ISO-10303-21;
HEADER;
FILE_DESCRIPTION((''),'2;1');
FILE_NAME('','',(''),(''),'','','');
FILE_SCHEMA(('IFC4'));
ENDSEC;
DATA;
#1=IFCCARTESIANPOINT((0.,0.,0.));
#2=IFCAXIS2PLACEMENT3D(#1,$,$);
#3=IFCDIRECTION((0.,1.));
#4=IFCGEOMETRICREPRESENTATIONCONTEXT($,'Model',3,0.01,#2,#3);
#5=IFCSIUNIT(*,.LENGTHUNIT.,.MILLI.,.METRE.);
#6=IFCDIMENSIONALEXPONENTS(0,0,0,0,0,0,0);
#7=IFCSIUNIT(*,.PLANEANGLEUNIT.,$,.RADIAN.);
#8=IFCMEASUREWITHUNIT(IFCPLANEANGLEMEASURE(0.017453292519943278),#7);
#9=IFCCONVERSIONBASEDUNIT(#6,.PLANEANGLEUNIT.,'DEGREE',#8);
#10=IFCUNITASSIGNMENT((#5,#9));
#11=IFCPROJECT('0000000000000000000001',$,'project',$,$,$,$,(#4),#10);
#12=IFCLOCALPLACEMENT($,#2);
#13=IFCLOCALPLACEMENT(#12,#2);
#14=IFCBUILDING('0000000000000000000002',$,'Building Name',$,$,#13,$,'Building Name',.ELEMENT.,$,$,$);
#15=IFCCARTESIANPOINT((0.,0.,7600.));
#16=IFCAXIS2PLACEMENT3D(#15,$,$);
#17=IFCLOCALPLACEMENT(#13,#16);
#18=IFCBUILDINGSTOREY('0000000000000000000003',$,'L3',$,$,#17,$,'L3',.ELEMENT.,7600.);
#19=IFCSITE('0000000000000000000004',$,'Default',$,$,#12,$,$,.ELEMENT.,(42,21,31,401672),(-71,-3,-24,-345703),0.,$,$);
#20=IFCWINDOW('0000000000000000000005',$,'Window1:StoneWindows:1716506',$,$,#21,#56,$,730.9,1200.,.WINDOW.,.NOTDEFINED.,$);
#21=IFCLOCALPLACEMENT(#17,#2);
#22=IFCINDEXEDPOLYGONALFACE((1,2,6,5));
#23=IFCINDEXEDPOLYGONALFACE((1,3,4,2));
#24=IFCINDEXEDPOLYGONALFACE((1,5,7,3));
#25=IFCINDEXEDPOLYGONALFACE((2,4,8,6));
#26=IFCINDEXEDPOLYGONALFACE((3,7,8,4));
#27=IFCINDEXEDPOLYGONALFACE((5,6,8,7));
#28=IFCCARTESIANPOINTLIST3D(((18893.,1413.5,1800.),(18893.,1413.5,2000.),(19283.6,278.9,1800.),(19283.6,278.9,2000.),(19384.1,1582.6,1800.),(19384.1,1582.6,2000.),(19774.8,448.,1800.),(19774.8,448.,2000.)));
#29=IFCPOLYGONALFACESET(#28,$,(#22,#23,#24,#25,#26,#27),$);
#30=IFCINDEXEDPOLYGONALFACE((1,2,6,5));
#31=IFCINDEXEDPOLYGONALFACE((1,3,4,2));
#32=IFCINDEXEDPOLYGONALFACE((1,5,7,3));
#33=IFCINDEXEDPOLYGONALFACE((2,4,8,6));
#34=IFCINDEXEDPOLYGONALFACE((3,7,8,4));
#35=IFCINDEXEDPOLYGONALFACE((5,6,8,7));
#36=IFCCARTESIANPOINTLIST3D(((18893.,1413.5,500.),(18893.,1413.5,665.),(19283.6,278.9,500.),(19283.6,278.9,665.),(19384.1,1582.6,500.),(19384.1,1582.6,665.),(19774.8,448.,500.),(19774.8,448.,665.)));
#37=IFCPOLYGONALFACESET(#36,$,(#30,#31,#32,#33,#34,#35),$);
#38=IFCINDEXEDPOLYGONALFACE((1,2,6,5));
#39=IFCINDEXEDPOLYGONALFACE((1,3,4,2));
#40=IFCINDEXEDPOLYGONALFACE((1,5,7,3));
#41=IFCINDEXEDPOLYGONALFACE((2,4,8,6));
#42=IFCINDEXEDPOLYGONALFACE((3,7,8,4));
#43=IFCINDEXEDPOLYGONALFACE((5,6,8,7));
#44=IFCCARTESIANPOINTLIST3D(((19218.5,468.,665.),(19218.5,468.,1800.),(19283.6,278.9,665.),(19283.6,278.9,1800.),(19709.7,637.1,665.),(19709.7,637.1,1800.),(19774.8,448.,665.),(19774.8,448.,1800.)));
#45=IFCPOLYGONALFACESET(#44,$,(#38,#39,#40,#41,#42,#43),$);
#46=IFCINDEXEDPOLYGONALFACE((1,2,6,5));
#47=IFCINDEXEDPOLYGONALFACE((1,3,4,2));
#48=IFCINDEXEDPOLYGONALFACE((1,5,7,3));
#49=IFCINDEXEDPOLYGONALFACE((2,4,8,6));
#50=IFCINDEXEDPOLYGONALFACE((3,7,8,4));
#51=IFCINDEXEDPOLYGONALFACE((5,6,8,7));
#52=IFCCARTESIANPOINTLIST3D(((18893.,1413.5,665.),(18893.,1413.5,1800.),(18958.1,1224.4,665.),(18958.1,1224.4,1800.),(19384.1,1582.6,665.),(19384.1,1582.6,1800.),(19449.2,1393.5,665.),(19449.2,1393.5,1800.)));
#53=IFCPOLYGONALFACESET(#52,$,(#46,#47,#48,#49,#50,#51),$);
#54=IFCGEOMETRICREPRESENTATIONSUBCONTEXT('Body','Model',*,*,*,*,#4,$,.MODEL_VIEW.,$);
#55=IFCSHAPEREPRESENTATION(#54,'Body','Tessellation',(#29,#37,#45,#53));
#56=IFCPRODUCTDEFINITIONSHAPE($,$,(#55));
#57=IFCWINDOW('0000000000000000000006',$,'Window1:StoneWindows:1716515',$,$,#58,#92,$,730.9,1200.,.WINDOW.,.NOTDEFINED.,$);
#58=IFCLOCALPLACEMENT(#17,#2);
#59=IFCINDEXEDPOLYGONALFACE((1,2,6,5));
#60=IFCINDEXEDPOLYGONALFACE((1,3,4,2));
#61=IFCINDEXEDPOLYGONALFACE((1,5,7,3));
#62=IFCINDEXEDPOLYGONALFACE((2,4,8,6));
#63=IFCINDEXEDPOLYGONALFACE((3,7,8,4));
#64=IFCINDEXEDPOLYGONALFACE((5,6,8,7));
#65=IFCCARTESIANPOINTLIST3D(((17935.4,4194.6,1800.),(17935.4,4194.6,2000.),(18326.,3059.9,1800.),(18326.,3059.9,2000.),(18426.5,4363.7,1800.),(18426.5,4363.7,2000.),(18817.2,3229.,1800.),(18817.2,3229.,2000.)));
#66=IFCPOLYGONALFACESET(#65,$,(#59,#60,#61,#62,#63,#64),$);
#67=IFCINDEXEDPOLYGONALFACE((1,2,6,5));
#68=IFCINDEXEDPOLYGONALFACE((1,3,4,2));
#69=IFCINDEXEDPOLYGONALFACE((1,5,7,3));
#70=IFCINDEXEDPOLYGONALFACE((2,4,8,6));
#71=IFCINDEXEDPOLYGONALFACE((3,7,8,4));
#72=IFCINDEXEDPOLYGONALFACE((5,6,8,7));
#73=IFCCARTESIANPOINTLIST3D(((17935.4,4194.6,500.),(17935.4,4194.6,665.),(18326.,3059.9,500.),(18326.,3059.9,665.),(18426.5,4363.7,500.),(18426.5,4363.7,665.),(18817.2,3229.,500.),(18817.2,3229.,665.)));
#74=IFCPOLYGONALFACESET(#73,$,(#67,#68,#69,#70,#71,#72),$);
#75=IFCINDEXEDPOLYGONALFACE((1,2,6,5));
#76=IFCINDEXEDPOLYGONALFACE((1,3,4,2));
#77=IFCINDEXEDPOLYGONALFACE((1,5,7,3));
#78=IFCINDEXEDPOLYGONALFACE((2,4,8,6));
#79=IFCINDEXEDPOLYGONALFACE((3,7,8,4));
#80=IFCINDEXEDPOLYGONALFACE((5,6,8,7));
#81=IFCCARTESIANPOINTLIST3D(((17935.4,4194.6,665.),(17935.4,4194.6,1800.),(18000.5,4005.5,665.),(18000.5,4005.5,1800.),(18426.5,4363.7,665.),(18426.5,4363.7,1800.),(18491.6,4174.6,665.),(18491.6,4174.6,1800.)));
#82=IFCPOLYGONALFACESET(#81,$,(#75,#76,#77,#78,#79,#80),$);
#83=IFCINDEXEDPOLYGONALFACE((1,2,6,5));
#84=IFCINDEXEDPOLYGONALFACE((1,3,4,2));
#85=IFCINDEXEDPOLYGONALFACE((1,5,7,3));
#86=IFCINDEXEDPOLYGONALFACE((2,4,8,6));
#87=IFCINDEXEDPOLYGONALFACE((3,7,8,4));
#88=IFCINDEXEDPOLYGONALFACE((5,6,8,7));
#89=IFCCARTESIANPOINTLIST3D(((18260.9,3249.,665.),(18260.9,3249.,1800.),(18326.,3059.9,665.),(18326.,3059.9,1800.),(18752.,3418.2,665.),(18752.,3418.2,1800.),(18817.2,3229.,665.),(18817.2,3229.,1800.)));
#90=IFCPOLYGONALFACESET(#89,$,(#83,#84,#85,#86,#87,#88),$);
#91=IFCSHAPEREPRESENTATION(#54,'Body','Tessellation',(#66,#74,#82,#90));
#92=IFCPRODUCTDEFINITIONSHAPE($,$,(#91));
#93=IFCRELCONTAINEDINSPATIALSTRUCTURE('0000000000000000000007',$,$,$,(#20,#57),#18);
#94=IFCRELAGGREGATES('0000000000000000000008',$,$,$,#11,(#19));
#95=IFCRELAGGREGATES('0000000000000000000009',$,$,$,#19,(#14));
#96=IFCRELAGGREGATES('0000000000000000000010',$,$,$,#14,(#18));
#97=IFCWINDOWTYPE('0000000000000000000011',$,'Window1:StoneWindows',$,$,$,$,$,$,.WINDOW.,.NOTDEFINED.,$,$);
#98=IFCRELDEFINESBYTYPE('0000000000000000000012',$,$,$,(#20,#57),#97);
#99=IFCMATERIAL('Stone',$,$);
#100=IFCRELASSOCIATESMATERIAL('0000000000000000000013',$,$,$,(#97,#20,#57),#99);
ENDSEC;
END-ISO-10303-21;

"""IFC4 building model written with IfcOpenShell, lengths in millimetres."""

from ifc_helpers import new_model, entity, si_unit, converted_unit, direction, frame, origin, place, context, subcontext, project, spatial, indexed_curve, outline, extrude, source, transform, mapped, material, type_object, type_shapes, element, save


model = new_model("IFC4")

# Units and contexts
model_context = context("Model", 3, precision=0.01, world=origin(), true_north=direction((0.0, 1.0)))
body_context = subcontext(model_context, "Body", "Model", "MODEL_VIEW")
ifc_project = project(units=[si_unit("LENGTHUNIT", "METRE", prefix="MILLI"), converted_unit("PLANEANGLEUNIT", "DEGREE", entity("IfcPlaneAngleMeasure", 0.017453292519943278), si_unit("PLANEANGLEUNIT", "RADIAN"), dimensions=[0, 0, 0, 0, 0, 0, 0])], contexts=[model_context])

# Site, building, storey
site_placement = place(None, origin())
site = spatial("IfcSite", under=ifc_project, at=site_placement, Name="Default", CompositionType="ELEMENT", RefLatitude=(42, 21, 31, 401672), RefLongitude=(-71, -3, -24, -345703), RefElevation=0.0)
building_placement = place(site_placement, origin())
building = spatial("IfcBuilding", under=site, at=building_placement, Name="Building Name", LongName="Building Name", CompositionType="ELEMENT")
storey_placement = place(building_placement, frame((0.0, 0.0, 7600.0)))
storey = spatial("IfcBuildingStorey", under=building, at=storey_placement, Name="L3", LongName="L3", CompositionType="ELEMENT", Elevation=7600.0)

# Shared definitions
ifc_material_1 = material(Name="Stone")

# Windows
window_type_1 = type_object("IfcWindowType", Name="Window1:StoneWindows", PartitioningType="NOTDEFINED", PredefinedType="WINDOW", material=ifc_material_1)
shared_shape_1 = source(origin(), body_context, "Body", "SweptSolid", [
    extrude(outline(indexed_curve([(-259.7, -600.0), (259.7, -600.0), (259.7, 600.0), (-259.7, 600.0), (-259.7, -600.0)], self_intersect=False)), frame((0.0, 0.0, 2100.0), z_axis=(0.0, 0.0, 1.0), x_axis=(0.0, 1.0, 0.0)), (0.0, 0.0, 1.0), 200.0),
    extrude(outline(indexed_curve([(-259.7, -600.0), (259.7, -600.0), (259.7, 600.0), (-259.7, 600.0), (-259.7, -600.0)], self_intersect=False)), frame((0.0, 0.0, 800.0), z_axis=(0.0, 0.0, 1.0), x_axis=(0.0, 1.0, 0.0)), (0.0, 0.0, 1.0), 165.0),
    extrude(outline(indexed_curve([(-259.7, -100.0), (259.7, -100.0), (259.7, 100.0), (-259.7, 100.0), (-259.7, -100.0)], self_intersect=False)), frame((-500.0, 0.0, 965.0), z_axis=(0.0, 0.0, 1.0), x_axis=(0.0, 1.0, 0.0)), (0.0, 0.0, 1.0), 1135.0),
    extrude(outline(indexed_curve([(-259.7, -100.0), (259.7, -100.0), (259.7, 100.0), (-259.7, 100.0), (-259.7, -100.0)], self_intersect=False)), frame((500.0, 0.0, 965.0), z_axis=(0.0, 0.0, 1.0), x_axis=(0.0, 1.0, 0.0)), (0.0, 0.0, 1.0), 1135.0),
])
type_shapes(window_type_1, [shared_shape_1])
for number, where, z_axis, x_axis, name in (
    (1, (19333.9, 930.7, -300.0), (0.0, 0.0, 1.0), (-0.325568, 0.945519, 0.0), "Window1:StoneWindows:1716506"),
    (2, (18376.3, 3711.8, -300.0), (0.0, 0.0, 1.0), (0.325568, -0.945519, 0.0), "Window1:StoneWindows:1716515"),
):
    element("IfcWindow", number, at=place(storey_placement, frame(where, z_axis=z_axis, x_axis=x_axis)), inside=storey, type_object=window_type_1, material=ifc_material_1, Name=name, OverallHeight=730.9, OverallWidth=1200.0, PartitioningType="NOTDEFINED", PredefinedType="WINDOW", context=body_context, shape_type="MappedRepresentation", body=[
        mapped(shared_shape_1, transform((0.0, 0.0, 0.0), scale=1.0)),
    ])

save(model, "model.ifc")
